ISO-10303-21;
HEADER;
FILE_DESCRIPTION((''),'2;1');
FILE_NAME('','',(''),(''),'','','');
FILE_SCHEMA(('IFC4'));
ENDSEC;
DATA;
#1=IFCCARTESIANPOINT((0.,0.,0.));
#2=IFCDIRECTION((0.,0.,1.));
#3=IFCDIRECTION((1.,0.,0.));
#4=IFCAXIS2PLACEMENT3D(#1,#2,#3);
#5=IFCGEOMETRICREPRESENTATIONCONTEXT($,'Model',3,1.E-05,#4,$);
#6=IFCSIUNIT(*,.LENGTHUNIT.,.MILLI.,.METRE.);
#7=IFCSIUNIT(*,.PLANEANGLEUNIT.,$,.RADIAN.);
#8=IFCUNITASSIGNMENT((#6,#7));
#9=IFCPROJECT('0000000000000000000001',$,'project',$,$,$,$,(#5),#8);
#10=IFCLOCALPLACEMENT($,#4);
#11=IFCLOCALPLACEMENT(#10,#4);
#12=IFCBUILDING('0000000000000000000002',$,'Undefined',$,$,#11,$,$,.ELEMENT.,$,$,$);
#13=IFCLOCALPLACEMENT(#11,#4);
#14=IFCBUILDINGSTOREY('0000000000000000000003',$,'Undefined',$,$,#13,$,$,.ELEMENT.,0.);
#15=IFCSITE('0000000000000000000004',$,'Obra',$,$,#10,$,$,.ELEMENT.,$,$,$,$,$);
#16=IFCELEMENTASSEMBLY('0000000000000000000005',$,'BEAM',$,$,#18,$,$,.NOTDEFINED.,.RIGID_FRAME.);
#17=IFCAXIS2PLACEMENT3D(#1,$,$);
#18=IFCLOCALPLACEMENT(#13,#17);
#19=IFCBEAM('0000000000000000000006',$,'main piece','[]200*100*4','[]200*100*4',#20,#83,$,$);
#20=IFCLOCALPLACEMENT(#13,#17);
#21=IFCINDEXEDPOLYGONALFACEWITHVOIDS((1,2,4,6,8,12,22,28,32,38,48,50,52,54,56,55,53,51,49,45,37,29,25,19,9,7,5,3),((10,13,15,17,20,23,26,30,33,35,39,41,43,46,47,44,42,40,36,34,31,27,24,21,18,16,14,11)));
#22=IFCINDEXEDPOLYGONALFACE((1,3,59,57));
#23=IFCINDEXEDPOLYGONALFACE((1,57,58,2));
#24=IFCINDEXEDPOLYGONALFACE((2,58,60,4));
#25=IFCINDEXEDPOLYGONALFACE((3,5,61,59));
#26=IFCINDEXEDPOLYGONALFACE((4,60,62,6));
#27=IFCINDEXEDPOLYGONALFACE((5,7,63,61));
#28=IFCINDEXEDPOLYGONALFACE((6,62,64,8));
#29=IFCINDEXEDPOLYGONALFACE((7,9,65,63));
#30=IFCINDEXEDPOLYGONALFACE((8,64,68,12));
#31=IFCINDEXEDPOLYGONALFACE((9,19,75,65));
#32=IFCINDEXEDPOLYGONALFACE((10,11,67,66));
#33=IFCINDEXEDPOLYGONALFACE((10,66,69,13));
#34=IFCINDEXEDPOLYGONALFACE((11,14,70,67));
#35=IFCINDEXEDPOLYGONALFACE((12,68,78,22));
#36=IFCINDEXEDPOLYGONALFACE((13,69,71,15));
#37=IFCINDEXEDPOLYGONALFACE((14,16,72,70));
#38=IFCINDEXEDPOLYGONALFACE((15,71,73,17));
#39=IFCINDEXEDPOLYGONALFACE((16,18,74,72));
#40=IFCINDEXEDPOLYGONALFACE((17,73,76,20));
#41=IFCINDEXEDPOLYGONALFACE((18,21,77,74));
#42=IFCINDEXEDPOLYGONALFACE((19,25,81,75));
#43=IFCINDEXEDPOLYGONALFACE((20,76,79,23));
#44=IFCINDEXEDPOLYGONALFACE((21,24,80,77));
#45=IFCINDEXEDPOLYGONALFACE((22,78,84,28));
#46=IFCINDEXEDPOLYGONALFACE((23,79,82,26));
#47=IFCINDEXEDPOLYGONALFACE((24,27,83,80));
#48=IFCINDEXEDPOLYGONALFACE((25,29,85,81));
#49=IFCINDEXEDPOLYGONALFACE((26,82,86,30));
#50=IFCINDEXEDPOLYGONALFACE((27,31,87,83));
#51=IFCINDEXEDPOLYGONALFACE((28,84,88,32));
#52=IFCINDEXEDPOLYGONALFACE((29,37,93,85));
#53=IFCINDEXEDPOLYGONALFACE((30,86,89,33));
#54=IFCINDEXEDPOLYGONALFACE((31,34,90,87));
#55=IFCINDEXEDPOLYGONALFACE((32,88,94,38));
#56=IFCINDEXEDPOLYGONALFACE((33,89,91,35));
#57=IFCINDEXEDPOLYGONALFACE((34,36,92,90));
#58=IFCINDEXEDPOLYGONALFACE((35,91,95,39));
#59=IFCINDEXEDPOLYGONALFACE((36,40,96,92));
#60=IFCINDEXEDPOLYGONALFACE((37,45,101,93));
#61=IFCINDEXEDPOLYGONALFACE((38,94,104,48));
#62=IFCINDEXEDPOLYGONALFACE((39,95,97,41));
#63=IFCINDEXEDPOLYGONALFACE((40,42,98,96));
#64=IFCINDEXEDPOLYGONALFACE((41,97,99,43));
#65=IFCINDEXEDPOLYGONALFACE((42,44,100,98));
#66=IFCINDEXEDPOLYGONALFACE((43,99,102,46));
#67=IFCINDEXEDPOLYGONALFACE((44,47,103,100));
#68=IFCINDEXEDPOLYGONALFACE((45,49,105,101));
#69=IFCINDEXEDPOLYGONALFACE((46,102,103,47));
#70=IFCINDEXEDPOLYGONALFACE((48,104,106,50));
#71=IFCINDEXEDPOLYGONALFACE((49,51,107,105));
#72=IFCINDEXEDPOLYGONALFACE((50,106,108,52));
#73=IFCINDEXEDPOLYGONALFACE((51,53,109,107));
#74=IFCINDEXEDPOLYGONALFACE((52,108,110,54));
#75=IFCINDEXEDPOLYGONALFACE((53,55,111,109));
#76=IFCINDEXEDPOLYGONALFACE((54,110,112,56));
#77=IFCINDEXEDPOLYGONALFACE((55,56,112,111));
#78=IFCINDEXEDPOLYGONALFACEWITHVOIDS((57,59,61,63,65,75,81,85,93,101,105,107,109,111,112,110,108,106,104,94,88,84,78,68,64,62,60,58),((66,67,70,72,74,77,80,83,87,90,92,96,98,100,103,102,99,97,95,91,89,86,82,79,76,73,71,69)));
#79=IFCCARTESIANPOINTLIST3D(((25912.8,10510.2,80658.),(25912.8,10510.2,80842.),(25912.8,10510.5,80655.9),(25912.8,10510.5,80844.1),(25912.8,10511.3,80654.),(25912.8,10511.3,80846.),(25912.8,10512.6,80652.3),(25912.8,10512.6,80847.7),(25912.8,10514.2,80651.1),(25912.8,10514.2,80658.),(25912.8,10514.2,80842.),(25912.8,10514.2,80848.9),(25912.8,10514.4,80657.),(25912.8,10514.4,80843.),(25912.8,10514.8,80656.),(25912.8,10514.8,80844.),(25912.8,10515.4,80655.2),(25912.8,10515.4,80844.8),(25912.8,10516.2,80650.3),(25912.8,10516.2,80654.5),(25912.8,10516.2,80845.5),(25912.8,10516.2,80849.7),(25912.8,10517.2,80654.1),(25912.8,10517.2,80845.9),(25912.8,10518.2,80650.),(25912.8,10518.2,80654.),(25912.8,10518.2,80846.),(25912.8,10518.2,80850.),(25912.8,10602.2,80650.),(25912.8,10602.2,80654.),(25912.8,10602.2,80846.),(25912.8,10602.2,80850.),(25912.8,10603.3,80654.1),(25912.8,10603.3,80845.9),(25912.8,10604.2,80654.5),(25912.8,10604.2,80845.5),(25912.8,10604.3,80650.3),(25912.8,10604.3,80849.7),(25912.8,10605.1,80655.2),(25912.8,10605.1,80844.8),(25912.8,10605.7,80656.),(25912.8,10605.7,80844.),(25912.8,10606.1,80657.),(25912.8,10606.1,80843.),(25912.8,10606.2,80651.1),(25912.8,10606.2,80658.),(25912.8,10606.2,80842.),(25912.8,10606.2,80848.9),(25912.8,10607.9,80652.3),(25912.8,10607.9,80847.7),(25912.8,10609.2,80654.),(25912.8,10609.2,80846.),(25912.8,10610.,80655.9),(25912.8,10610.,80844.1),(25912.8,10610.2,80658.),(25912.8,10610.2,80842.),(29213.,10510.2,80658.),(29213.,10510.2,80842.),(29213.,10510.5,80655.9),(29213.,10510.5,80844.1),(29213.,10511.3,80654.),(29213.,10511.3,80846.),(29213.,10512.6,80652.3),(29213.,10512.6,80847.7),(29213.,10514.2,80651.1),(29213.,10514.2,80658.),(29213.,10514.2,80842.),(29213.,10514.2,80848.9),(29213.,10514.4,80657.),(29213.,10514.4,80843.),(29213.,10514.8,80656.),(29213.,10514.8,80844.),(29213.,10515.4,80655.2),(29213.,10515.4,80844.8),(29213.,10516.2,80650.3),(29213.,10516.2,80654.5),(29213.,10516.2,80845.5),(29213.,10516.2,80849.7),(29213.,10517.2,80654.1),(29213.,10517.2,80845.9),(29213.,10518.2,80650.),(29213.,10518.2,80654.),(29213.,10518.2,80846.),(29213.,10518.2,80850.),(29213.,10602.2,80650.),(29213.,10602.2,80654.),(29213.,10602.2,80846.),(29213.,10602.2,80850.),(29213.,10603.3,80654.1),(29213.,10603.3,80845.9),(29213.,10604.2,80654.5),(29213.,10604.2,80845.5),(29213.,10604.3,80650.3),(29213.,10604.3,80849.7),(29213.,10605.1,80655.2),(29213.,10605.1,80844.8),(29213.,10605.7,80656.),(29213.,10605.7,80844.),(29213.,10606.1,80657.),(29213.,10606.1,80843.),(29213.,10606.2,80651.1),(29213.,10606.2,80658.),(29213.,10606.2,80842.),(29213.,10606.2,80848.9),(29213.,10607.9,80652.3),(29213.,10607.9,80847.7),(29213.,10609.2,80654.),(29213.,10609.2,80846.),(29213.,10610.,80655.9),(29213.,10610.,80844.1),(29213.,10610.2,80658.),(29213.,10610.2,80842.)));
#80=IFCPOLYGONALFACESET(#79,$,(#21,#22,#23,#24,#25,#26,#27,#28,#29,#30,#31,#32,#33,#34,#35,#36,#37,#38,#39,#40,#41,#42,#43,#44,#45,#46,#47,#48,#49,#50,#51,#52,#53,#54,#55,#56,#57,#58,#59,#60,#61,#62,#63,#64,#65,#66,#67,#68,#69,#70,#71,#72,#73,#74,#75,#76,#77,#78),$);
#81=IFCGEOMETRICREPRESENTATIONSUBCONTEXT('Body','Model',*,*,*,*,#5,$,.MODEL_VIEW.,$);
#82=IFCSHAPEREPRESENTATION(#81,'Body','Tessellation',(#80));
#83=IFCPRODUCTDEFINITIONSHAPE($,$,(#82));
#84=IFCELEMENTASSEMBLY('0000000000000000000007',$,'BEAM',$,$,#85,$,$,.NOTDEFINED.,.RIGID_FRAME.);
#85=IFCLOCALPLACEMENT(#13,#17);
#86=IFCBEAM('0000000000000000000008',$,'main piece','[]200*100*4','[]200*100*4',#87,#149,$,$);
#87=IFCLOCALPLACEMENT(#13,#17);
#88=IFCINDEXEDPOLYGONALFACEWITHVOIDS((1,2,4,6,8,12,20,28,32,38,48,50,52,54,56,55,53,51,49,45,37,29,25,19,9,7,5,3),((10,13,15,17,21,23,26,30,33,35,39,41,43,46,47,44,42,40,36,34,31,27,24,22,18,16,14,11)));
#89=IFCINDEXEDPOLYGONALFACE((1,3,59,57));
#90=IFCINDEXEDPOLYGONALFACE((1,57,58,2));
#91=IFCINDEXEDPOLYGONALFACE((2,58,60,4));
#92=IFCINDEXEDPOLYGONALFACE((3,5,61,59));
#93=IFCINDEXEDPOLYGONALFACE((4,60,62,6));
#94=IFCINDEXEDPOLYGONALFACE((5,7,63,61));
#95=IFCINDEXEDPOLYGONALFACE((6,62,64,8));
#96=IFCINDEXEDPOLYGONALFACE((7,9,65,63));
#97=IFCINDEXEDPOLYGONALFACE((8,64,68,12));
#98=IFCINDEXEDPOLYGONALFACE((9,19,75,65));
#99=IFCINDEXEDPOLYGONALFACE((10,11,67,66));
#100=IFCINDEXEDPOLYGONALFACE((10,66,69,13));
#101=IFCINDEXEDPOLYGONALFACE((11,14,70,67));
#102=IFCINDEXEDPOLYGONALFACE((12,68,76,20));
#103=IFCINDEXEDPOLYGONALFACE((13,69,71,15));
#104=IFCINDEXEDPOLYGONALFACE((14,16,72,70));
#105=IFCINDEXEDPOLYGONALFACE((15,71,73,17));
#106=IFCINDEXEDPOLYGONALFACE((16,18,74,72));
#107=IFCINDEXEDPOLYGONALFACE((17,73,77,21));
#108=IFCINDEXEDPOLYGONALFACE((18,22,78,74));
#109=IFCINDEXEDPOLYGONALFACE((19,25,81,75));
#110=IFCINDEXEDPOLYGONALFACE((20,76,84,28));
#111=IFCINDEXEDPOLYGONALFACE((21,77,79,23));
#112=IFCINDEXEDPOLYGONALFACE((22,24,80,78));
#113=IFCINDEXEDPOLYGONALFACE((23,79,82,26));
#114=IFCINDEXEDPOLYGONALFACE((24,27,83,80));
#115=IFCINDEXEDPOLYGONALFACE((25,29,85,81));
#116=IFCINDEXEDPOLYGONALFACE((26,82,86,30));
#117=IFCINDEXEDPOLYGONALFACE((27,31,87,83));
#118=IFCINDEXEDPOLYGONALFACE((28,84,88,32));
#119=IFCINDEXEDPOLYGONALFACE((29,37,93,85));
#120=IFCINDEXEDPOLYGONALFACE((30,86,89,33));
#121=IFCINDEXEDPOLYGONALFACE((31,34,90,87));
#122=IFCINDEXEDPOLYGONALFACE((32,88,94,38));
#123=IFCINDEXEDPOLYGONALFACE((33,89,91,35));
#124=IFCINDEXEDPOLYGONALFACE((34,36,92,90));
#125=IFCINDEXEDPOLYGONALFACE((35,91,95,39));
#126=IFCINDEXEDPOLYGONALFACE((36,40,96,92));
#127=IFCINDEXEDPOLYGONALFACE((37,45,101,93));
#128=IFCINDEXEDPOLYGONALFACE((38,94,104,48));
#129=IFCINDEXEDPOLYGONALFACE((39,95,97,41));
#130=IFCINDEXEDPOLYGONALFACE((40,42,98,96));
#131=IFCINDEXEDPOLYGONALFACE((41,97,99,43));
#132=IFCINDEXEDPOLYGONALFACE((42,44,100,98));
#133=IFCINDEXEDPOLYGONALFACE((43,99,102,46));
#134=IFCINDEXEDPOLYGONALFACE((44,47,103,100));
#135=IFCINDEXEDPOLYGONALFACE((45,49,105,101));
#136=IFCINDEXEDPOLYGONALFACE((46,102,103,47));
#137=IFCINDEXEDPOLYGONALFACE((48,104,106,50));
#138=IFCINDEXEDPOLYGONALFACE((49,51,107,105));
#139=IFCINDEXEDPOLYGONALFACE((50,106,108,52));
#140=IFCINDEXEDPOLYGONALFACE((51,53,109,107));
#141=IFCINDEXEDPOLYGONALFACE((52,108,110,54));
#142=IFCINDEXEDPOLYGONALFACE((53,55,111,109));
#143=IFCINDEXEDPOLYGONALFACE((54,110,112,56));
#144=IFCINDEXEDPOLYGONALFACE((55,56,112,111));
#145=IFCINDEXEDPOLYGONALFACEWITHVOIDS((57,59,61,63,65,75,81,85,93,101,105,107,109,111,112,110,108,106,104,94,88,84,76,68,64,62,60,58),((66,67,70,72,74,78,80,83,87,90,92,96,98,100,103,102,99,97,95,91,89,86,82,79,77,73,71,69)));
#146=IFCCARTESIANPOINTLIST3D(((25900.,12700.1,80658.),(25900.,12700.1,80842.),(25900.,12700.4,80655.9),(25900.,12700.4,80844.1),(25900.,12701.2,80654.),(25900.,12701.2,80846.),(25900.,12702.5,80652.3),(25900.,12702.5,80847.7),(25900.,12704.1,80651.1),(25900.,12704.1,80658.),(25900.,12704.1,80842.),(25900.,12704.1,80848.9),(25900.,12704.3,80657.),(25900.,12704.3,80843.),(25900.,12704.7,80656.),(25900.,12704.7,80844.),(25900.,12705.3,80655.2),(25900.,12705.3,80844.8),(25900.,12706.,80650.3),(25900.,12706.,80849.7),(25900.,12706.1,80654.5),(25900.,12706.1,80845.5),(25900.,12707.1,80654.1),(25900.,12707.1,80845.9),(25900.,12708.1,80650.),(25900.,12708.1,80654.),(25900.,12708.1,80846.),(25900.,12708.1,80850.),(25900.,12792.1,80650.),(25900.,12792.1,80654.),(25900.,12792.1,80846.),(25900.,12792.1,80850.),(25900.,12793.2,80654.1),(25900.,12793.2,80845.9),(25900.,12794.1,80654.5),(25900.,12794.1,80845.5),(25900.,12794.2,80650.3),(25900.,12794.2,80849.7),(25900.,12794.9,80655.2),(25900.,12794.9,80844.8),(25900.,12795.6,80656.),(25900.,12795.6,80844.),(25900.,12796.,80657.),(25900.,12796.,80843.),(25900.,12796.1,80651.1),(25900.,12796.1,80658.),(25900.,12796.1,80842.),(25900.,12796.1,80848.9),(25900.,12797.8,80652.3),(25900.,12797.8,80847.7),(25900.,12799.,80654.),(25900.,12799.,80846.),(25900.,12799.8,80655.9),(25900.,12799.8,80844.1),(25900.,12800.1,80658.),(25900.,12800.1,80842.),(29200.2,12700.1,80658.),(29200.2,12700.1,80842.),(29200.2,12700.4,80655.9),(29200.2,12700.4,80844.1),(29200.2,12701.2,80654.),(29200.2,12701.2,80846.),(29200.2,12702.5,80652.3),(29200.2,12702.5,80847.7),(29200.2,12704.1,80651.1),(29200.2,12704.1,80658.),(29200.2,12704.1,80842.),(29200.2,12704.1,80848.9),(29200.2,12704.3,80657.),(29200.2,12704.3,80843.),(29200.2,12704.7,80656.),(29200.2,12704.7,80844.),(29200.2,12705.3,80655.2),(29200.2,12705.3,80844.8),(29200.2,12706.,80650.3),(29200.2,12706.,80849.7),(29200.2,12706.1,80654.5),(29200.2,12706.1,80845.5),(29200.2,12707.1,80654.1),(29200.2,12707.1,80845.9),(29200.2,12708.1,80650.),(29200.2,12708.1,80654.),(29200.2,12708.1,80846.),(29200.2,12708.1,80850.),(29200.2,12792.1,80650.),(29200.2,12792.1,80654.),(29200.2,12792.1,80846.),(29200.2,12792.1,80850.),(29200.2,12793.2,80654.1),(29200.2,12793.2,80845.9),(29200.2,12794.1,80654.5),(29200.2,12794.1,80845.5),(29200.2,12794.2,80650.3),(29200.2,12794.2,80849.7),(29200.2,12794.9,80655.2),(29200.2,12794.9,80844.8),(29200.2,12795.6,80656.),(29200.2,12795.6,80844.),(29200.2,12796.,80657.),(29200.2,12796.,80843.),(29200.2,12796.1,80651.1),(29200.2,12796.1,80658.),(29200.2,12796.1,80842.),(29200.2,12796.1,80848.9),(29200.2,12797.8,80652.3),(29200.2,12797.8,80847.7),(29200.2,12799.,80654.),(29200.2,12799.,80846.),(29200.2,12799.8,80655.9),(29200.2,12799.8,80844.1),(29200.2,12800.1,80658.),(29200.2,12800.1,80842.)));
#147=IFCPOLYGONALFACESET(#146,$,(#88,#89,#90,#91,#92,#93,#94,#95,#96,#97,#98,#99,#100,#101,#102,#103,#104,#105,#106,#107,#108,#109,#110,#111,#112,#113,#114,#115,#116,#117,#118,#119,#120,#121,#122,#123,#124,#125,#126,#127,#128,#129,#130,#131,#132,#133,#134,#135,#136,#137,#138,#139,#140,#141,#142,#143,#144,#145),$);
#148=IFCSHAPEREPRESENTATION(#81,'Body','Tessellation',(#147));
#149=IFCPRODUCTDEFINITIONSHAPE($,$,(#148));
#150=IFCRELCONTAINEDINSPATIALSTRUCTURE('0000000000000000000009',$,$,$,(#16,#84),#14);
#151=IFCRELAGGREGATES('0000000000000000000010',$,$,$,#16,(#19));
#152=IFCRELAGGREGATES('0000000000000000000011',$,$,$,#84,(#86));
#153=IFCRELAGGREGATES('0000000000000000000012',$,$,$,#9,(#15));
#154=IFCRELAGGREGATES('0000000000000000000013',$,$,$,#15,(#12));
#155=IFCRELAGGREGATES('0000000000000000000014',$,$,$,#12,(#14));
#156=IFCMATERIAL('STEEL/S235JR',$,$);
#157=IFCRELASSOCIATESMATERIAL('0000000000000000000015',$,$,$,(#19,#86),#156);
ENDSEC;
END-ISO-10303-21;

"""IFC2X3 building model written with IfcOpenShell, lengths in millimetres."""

from ifc_helpers import new_model, si_unit, frame, origin_with_axes, origin_2d_with_axis, place, context, subcontext, project, spatial, hollow_rectangle, extrude, material, element, aggregate, save


model = new_model("IFC2X3")

# Units and contexts
model_context = context("Model", 3, precision=1e-05, world=origin_with_axes())
body_context = subcontext(model_context, "Body", "Model", "MODEL_VIEW")
ifc_project = project(units=[si_unit("LENGTHUNIT", "METRE", prefix="MILLI"), si_unit("PLANEANGLEUNIT", "RADIAN")], contexts=[model_context])

# Site, building, storey
site_placement = place(None, origin_with_axes())
site = spatial("IfcSite", under=ifc_project, at=site_placement, Name="Obra", CompositionType="ELEMENT")
building_placement = place(site_placement, origin_with_axes())
building = spatial("IfcBuilding", under=site, at=building_placement, Name="Undefined", CompositionType="ELEMENT")
storey_placement = place(building_placement, origin_with_axes())
storey = spatial("IfcBuildingStorey", under=building, at=storey_placement, Name="Undefined", CompositionType="ELEMENT", Elevation=0.0)

# Shared definitions
ifc_material = material(Name="STEEL/S235JR")

# Element assemblies, beams
assembly_1_placement = place(storey_placement, origin_with_axes())
assembly_1 = element("IfcElementAssembly", 1, at=assembly_1_placement, inside=storey, Name="BEAM", AssemblyPlace="NOTDEFINED", PredefinedType="RIGID_FRAME")
beam_1_placement = place(assembly_1_placement, frame((25912.8, 10560.2, 80750.0), z_axis=(0.0, 0.0, 1.0), x_axis=(1.0, 0.0, 0.0)))
beam_1 = element("IfcBeam", 2, at=beam_1_placement, material=ifc_material, Name="main piece", Description="[]200*100*4", ObjectType="[]200*100*4", context=body_context, shape_type="SweptSolid", body=[
    extrude(hollow_rectangle(XDim=100.0, YDim=200.0, WallThickness=4.0, InnerFilletRadius=4.0, OuterFilletRadius=8.0, at=origin_2d_with_axis()), frame((3300.2, 0.0, 0.0), z_axis=(-1.0, 0.0, 0.0), x_axis=(0.0, -1.0, 0.0)), (0.0, 0.0, 1.0), 3300.2),
])
aggregate(assembly_1, [beam_1])
assembly_2_placement = place(storey_placement, origin_with_axes())
assembly_2 = element("IfcElementAssembly", 3, at=assembly_2_placement, inside=storey, Name="BEAM", AssemblyPlace="NOTDEFINED", PredefinedType="RIGID_FRAME")
beam_2_placement = place(assembly_2_placement, frame((25900.1, 12750.1, 80750.0), z_axis=(0.0, 0.0, 1.0), x_axis=(1.0, 0.0, 0.0)))
beam_2 = element("IfcBeam", 4, at=beam_2_placement, material=ifc_material, Name="main piece", Description="[]200*100*4", ObjectType="[]200*100*4", context=body_context, shape_type="SweptSolid", body=[
    extrude(hollow_rectangle(XDim=100.0, YDim=200.0, WallThickness=4.0, InnerFilletRadius=4.0, OuterFilletRadius=8.0, at=origin_2d_with_axis()), frame((3300.2, 0.0, 0.0), z_axis=(-1.0, 0.0, 0.0), x_axis=(0.0, -1.0, 0.0)), (0.0, 0.0, 1.0), 3300.2),
])
aggregate(assembly_2, [beam_2])

save(model, "model.ifc")
